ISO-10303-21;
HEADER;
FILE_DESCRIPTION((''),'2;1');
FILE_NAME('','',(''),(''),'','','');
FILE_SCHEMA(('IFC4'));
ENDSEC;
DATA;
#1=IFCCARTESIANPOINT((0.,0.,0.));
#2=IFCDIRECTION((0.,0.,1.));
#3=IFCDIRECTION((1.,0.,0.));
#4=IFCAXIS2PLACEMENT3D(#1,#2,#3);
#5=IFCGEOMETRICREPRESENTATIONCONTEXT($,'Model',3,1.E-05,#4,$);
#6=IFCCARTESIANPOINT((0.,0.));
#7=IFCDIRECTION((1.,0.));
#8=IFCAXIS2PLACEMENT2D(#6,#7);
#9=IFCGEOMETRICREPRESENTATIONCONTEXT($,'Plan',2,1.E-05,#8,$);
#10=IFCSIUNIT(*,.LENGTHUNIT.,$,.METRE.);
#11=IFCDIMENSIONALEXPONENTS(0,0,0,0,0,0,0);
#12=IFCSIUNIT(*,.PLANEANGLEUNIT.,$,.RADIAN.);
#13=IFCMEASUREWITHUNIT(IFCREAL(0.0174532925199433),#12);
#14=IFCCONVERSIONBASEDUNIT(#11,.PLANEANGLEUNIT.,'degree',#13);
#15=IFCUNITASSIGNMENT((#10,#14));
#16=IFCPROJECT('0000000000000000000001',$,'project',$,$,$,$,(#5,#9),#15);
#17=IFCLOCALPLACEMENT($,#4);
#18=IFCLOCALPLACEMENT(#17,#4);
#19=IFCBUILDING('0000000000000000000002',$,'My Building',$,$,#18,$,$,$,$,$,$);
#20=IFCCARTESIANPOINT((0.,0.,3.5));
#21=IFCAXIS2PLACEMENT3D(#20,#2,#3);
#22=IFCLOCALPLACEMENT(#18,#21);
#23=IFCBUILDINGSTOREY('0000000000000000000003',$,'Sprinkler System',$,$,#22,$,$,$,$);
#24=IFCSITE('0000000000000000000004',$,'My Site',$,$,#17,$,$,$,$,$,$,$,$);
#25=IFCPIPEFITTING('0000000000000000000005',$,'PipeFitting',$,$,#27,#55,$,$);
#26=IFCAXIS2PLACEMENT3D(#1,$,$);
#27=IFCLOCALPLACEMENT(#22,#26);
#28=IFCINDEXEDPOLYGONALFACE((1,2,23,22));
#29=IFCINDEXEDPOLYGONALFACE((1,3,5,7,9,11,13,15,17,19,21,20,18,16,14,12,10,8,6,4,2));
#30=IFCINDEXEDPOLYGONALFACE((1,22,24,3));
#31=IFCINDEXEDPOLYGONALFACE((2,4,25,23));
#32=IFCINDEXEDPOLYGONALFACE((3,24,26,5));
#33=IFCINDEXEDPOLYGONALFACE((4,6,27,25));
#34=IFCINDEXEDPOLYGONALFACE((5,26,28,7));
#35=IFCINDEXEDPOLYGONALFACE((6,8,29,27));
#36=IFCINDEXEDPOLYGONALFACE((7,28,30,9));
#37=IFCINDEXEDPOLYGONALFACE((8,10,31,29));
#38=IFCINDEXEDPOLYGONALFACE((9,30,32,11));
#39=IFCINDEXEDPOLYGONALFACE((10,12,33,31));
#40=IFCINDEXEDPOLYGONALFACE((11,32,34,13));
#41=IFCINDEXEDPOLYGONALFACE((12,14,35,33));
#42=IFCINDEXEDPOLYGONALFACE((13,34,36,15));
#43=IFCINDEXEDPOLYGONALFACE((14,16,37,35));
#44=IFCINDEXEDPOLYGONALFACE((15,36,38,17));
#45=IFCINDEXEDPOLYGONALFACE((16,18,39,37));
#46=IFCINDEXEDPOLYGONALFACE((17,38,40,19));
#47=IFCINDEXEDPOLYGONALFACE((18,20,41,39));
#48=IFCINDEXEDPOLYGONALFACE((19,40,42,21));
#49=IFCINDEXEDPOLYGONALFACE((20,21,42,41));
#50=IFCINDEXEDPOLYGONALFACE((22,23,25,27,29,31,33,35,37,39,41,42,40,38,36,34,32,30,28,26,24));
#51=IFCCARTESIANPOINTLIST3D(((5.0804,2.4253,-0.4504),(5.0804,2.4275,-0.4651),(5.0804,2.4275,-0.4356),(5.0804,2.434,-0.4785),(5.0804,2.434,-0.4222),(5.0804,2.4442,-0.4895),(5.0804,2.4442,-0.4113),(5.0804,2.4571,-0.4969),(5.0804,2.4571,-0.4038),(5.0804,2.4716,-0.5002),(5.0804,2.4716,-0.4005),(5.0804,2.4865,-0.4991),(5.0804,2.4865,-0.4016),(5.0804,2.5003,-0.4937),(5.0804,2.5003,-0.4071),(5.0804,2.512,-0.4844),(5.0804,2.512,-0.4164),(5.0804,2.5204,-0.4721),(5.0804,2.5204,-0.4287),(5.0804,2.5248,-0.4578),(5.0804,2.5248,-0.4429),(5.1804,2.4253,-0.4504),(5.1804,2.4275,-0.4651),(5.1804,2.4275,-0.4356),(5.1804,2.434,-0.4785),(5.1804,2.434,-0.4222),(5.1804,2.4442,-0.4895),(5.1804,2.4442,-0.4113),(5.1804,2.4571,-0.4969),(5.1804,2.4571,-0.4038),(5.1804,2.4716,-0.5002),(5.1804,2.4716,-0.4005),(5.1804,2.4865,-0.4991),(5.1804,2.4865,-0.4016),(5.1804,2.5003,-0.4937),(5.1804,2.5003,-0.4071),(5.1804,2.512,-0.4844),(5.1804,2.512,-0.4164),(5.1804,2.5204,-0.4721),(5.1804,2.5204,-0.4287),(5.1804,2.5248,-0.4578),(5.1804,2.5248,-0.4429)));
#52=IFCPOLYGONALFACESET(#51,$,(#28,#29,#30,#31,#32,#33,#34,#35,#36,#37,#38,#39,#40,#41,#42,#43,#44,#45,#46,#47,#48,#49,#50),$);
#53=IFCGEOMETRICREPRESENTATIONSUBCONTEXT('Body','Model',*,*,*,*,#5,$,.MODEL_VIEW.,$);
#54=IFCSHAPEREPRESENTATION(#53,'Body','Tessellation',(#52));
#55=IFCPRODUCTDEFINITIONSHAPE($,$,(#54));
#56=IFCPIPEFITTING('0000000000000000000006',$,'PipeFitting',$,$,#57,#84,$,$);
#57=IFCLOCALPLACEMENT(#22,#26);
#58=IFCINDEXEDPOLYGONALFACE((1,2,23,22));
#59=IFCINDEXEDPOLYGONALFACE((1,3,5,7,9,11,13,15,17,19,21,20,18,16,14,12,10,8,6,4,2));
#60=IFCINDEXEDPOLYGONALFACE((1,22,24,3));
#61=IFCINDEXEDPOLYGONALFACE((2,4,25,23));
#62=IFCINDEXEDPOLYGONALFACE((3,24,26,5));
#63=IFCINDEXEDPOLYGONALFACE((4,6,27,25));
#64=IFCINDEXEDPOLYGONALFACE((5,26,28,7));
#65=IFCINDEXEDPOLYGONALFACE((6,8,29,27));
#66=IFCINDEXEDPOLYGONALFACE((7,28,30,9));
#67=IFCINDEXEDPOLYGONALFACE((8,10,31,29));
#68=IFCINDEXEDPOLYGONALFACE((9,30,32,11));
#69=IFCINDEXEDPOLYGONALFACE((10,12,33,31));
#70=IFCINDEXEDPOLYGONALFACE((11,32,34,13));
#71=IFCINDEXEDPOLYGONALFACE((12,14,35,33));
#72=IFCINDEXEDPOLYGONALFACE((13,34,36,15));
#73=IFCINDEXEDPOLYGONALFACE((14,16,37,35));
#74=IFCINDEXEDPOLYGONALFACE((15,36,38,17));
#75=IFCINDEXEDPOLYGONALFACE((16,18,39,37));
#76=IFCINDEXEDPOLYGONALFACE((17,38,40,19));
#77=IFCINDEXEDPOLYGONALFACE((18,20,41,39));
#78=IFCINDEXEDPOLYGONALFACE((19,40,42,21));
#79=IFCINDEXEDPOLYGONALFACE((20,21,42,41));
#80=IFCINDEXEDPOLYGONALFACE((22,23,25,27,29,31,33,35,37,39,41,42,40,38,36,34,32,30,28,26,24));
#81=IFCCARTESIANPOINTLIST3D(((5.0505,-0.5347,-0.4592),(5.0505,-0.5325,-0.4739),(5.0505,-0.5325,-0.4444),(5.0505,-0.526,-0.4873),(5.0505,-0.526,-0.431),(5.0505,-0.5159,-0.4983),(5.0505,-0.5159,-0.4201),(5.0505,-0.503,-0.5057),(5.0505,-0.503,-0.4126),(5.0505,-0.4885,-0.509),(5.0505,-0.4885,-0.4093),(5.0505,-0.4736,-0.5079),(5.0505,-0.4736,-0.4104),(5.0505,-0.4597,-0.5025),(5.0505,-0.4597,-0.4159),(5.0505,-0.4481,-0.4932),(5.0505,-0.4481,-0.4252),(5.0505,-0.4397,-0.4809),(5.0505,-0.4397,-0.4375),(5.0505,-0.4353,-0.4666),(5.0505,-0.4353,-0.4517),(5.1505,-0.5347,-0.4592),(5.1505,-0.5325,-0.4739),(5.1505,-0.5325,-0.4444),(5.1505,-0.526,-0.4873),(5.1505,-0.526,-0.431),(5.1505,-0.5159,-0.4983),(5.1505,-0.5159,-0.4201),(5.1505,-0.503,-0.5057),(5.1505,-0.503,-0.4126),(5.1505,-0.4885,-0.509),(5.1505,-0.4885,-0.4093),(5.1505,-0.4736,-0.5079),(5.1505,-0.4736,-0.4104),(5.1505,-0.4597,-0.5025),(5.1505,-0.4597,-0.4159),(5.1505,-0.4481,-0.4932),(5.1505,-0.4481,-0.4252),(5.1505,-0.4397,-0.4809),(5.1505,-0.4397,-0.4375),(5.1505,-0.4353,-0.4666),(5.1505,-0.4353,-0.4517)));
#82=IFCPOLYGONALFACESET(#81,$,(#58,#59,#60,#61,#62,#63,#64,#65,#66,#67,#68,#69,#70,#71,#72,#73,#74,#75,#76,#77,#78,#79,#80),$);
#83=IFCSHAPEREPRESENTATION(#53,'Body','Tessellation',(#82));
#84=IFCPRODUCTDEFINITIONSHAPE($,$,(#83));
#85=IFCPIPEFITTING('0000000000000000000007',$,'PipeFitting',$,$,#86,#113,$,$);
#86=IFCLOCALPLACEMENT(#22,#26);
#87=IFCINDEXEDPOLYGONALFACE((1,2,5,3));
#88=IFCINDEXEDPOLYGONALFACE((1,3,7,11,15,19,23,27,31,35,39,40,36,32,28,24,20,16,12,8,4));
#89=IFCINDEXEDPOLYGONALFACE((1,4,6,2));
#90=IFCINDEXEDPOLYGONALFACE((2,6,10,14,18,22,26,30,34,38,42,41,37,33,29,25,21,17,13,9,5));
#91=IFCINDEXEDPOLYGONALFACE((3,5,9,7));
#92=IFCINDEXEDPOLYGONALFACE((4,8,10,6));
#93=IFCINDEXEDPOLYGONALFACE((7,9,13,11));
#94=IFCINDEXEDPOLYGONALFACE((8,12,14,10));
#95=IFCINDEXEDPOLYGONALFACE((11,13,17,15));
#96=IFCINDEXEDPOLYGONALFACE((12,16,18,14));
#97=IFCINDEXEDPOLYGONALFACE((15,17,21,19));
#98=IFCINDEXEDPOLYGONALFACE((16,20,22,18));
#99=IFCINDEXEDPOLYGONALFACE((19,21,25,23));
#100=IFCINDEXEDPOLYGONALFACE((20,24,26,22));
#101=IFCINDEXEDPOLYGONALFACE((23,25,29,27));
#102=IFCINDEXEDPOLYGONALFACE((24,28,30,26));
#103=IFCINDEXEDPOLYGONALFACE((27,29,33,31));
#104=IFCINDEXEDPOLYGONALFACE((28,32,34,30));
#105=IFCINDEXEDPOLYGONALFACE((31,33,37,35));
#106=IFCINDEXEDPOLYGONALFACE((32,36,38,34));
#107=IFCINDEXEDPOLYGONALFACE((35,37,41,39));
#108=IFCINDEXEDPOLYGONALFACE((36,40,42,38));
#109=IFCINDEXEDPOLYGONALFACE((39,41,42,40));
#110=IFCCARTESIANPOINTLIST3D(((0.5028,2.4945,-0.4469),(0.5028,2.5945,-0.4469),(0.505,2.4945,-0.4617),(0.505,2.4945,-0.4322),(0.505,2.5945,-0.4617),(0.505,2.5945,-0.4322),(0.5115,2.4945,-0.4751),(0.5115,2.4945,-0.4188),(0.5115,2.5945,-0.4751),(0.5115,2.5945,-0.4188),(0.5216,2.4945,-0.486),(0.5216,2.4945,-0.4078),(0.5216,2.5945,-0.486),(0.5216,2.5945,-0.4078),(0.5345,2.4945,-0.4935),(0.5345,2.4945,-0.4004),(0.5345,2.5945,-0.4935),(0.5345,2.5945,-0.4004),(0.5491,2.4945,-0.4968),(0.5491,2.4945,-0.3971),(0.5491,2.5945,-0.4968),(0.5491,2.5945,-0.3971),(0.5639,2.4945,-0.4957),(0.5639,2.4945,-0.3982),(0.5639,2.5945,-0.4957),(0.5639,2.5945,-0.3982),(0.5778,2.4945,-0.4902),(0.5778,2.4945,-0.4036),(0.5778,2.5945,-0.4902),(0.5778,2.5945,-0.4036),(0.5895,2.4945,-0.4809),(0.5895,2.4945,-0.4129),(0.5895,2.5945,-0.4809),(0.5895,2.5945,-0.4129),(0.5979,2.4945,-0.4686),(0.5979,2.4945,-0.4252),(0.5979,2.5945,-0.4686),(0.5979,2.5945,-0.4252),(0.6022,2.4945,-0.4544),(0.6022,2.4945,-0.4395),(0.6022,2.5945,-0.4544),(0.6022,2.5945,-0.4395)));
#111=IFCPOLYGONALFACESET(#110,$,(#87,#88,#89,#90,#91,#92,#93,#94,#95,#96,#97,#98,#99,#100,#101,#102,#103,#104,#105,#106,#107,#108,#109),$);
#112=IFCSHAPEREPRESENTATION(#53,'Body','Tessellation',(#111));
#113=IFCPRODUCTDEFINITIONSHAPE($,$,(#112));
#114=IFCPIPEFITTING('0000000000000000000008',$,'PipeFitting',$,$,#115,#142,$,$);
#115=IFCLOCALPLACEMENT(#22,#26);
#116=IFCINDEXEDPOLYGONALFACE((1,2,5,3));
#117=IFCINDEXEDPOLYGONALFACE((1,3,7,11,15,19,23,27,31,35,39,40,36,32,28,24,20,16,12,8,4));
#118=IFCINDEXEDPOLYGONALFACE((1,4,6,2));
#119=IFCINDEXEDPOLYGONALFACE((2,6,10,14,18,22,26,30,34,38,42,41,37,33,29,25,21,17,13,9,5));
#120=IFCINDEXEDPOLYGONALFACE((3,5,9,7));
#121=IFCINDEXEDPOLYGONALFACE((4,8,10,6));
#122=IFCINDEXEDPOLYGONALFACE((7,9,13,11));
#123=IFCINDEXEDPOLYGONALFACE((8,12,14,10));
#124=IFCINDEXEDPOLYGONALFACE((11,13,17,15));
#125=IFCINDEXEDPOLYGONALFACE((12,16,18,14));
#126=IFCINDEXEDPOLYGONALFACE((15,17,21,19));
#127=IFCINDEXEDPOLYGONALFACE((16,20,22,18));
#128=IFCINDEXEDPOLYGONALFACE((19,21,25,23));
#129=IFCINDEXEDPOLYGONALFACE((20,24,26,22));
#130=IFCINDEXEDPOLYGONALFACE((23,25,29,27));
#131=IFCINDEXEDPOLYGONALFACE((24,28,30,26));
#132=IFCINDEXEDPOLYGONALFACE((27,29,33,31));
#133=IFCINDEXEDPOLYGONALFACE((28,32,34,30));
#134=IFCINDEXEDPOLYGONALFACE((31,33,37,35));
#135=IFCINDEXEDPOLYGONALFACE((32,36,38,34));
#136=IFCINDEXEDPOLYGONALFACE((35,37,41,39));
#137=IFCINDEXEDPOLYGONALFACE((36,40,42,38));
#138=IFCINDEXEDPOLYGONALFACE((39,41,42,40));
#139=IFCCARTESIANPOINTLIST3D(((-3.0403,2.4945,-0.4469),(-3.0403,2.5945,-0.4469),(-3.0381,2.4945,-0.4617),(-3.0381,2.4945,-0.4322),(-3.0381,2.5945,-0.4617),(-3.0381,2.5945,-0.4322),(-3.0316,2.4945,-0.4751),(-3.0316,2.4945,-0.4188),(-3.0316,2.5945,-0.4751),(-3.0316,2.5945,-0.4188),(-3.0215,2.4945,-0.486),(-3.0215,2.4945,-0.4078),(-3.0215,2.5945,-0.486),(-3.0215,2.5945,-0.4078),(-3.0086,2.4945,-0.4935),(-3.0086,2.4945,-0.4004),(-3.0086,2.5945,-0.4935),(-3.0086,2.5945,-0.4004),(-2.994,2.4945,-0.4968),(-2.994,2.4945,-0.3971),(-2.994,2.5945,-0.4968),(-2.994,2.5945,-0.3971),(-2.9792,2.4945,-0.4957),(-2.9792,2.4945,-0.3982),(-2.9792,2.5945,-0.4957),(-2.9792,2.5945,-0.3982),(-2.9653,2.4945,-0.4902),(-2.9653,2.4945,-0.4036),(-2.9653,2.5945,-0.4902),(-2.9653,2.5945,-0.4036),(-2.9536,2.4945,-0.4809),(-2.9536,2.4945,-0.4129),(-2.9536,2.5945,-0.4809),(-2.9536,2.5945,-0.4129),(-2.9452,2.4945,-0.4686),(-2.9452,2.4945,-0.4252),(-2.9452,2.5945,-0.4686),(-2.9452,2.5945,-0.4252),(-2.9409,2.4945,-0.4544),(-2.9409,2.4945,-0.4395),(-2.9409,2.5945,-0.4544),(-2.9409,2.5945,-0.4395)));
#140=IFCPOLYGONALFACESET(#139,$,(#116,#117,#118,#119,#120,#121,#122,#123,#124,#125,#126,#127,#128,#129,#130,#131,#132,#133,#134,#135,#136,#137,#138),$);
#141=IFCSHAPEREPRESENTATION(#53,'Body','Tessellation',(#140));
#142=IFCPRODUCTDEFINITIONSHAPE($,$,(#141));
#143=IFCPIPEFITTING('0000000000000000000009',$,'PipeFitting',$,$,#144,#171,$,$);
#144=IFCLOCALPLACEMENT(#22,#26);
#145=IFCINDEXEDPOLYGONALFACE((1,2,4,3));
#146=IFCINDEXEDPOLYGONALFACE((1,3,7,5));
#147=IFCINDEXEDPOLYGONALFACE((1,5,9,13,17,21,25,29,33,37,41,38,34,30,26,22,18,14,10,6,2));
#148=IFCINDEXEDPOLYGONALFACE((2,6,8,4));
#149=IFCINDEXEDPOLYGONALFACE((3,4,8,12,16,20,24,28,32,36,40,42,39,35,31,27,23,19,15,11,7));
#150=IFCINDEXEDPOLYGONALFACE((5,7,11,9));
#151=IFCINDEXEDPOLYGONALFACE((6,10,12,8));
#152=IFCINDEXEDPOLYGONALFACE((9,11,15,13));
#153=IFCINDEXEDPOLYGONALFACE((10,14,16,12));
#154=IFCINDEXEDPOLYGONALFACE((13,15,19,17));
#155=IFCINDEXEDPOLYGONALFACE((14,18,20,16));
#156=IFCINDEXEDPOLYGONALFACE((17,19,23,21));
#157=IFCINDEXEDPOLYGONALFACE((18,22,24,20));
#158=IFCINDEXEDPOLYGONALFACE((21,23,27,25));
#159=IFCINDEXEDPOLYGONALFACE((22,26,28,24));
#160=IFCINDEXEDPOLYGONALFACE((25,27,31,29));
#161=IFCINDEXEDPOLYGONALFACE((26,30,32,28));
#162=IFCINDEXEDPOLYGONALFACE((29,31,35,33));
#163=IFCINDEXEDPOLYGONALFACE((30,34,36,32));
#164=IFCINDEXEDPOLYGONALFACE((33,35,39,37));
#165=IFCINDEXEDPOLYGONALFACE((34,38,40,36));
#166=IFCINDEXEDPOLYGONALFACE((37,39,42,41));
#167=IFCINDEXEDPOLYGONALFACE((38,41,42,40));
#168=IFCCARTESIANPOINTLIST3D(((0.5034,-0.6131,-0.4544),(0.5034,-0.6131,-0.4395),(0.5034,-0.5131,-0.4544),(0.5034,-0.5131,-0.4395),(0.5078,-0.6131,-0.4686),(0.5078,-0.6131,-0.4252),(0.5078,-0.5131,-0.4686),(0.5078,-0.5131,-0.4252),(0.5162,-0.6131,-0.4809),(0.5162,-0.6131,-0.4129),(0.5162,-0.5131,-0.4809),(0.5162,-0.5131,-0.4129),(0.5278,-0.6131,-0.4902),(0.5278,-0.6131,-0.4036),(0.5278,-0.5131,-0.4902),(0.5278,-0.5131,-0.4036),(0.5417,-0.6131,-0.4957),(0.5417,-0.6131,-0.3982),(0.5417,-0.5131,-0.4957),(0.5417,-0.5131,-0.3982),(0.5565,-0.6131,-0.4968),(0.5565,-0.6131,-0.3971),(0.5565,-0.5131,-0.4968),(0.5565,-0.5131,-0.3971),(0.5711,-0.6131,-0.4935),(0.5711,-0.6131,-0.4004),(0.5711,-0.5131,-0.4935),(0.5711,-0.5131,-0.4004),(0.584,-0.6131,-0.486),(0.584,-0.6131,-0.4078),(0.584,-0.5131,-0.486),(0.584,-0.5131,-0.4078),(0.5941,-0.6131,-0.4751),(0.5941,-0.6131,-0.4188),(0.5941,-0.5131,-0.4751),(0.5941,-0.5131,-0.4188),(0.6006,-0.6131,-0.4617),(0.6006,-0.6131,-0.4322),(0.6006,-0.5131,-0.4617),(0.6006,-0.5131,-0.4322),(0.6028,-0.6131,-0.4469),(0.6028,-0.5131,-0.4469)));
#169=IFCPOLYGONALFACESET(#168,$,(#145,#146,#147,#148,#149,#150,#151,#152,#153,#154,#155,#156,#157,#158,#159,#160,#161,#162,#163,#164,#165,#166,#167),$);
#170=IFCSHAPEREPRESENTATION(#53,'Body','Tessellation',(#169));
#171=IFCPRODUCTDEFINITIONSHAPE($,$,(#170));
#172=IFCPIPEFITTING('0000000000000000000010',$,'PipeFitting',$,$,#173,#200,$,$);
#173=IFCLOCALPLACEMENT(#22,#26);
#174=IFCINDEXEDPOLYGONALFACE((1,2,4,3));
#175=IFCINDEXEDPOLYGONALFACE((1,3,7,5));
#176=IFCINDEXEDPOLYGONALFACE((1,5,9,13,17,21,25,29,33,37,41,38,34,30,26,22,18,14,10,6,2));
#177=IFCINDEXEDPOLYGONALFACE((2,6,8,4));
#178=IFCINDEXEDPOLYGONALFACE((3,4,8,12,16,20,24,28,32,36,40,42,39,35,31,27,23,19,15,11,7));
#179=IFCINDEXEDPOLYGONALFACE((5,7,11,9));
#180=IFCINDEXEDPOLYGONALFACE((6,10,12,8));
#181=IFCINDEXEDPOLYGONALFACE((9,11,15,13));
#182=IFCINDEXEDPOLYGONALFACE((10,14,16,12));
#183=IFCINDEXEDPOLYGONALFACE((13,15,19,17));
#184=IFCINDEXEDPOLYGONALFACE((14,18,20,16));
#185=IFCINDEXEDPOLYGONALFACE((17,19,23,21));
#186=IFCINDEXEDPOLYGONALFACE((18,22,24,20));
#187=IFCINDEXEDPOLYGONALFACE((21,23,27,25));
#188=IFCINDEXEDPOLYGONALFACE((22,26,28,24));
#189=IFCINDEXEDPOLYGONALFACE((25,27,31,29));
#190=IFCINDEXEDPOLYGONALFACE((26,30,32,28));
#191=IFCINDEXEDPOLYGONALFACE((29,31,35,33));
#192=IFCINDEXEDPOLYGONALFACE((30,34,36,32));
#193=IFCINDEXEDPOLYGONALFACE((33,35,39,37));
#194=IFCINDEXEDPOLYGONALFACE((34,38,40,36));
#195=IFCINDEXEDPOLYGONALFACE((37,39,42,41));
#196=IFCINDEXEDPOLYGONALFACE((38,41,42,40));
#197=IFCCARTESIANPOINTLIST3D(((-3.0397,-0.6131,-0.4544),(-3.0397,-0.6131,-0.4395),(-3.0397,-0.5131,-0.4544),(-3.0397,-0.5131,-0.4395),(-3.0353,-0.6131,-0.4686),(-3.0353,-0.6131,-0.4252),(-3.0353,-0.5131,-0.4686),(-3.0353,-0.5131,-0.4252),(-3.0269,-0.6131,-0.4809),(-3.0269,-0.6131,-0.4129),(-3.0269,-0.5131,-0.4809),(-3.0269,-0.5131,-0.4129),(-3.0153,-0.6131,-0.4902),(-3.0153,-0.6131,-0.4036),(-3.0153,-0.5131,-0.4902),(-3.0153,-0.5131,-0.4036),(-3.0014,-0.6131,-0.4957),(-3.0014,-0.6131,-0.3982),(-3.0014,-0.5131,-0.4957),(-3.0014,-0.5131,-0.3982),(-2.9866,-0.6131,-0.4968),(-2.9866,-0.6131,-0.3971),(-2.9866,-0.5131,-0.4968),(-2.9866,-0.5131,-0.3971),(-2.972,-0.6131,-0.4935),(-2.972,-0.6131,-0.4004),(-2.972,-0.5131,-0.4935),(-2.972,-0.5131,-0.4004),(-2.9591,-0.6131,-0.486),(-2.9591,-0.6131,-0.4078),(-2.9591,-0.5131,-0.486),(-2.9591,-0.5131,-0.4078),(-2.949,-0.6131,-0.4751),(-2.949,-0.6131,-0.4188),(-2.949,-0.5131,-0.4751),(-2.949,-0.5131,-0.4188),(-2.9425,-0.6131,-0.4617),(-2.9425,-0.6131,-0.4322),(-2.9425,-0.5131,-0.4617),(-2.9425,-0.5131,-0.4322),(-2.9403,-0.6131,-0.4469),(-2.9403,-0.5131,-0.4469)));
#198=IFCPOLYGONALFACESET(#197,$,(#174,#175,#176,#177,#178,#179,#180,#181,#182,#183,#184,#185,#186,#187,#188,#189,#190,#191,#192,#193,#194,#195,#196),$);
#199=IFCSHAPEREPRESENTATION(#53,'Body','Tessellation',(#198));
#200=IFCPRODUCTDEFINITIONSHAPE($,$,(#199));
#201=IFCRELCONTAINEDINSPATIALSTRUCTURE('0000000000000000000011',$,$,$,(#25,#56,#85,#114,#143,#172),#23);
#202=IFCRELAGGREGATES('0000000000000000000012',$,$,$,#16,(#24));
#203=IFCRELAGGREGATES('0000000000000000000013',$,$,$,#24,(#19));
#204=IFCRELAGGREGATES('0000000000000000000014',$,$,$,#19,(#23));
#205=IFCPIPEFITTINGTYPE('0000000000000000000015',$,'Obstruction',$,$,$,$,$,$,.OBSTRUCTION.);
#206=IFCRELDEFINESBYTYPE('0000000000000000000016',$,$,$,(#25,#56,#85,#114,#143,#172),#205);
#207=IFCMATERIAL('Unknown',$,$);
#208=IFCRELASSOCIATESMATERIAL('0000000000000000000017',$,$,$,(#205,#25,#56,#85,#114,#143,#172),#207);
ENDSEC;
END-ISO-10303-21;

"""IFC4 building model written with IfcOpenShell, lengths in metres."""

from ifc_helpers import new_model, entity, si_unit, converted_unit, frame, origin_with_axes, origin_2d_with_axis, place, context, subcontext, project, spatial, circle, extrude, material, material_profile, profile_set, profile_usage, type_object, element, save


model = new_model("IFC4")

# Units and contexts
model_context = context("Model", 3, precision=1e-05, world=origin_with_axes())
plan_context = context("Plan", 2, precision=1e-05, world=origin_2d_with_axis())
body_context = subcontext(model_context, "Body", "Model", "MODEL_VIEW")
ifc_project = project(units=[si_unit("LENGTHUNIT", "METRE"), converted_unit("PLANEANGLEUNIT", "degree", entity("IfcReal", 0.0174532925199433), si_unit("PLANEANGLEUNIT", "RADIAN"), dimensions=[0, 0, 0, 0, 0, 0, 0])], contexts=[model_context, plan_context])

# Site, building, storey
site_placement = place(None, origin_with_axes())
site = spatial("IfcSite", under=ifc_project, at=site_placement, Name="My Site")
building_placement = place(site_placement, origin_with_axes())
building = spatial("IfcBuilding", under=site, at=building_placement, Name="My Building")
storey_placement = place(building_placement, frame((0.0, 0.0, 3.5), z_axis=(0.0, 0.0, 1.0), x_axis=(1.0, 0.0, 0.0)))
storey = spatial("IfcBuildingStorey", under=building, at=storey_placement, Name="Sprinkler System")

# Shared definitions
ifc_material = material(Name="Unknown")

# Pipe fittings
ifc_material_profile_1 = material_profile(ifc_material, circle(Radius=0.05))
ifc_profile_set_1 = profile_set([ifc_material_profile_1])
pipe_fitting_type_1 = type_object("IfcPipeFittingType", Name="Obstruction", PredefinedType="OBSTRUCTION", material=ifc_profile_set_1)
ifc_profile_usage_1 = profile_usage(ifc_profile_set_1, cardinal=5)
pipe_fitting_1_placement = place(storey_placement, frame((5.1804, 2.4753, -0.4504), z_axis=(-1.0, 0.0, 0.0), x_axis=(0.0, -1.0, 0.0)))
element("IfcPipeFitting", 1, at=pipe_fitting_1_placement, inside=storey, type_object=pipe_fitting_type_1, material=ifc_profile_usage_1, Name="PipeFitting", context=body_context, shape_type="SweptSolid", body=[
    extrude(circle(Radius=0.05), origin_with_axes(), (0.0, 0.0, 1.0), 0.1),
])
ifc_profile_usage_2 = profile_usage(ifc_profile_set_1, cardinal=5)
pipe_fitting_2_placement = place(storey_placement, frame((5.1505, -0.4847, -0.4592), z_axis=(-1.0, 0.0, 0.0), x_axis=(0.0, -1.0, 0.0)))
element("IfcPipeFitting", 2, at=pipe_fitting_2_placement, inside=storey, type_object=pipe_fitting_type_1, material=ifc_profile_usage_2, Name="PipeFitting", context=body_context, shape_type="SweptSolid", body=[
    extrude(circle(Radius=0.05), origin_with_axes(), (0.0, 0.0, 1.0), 0.1),
])
ifc_profile_usage_3 = profile_usage(ifc_profile_set_1, cardinal=5)
pipe_fitting_3_placement = place(storey_placement, frame((0.5528, 2.4945, -0.4469), z_axis=(0.0, 1.0, -0.00001), x_axis=(-1.0, 0.0, 0.0)))
element("IfcPipeFitting", 3, at=pipe_fitting_3_placement, inside=storey, type_object=pipe_fitting_type_1, material=ifc_profile_usage_3, Name="PipeFitting", context=body_context, shape_type="SweptSolid", body=[
    extrude(circle(Radius=0.05), origin_with_axes(), (0.0, 0.0, 1.0), 0.1),
])
ifc_profile_usage_4 = profile_usage(ifc_profile_set_1, cardinal=5)
pipe_fitting_4_placement = place(storey_placement, frame((-2.9903, 2.4945, -0.4469), z_axis=(0.0, 1.0, -0.00001), x_axis=(-1.0, 0.0, 0.0)))
element("IfcPipeFitting", 4, at=pipe_fitting_4_placement, inside=storey, type_object=pipe_fitting_type_1, material=ifc_profile_usage_4, Name="PipeFitting", context=body_context, shape_type="SweptSolid", body=[
    extrude(circle(Radius=0.05), origin_with_axes(), (0.0, 0.0, 1.0), 0.1),
])
ifc_profile_usage_5 = profile_usage(ifc_profile_set_1, cardinal=5)
pipe_fitting_5_placement = place(storey_placement, frame((0.5528, -0.5131, -0.4469), z_axis=(0.0, -1.0, -0.00001), x_axis=(1.0, 0.0, 0.0)))
element("IfcPipeFitting", 5, at=pipe_fitting_5_placement, inside=storey, type_object=pipe_fitting_type_1, material=ifc_profile_usage_5, Name="PipeFitting", context=body_context, shape_type="SweptSolid", body=[
    extrude(circle(Radius=0.05), origin_with_axes(), (0.0, 0.0, 1.0), 0.1),
])
ifc_profile_usage_6 = profile_usage(ifc_profile_set_1, cardinal=5)
pipe_fitting_6_placement = place(storey_placement, frame((-2.9903, -0.5131, -0.4469), z_axis=(0.0, -1.0, -0.00001), x_axis=(1.0, 0.0, 0.0)))
element("IfcPipeFitting", 6, at=pipe_fitting_6_placement, inside=storey, type_object=pipe_fitting_type_1, material=ifc_profile_usage_6, Name="PipeFitting", context=body_context, shape_type="SweptSolid", body=[
    extrude(circle(Radius=0.05), origin_with_axes(), (0.0, 0.0, 1.0), 0.1),
])

save(model, "model.ifc")
